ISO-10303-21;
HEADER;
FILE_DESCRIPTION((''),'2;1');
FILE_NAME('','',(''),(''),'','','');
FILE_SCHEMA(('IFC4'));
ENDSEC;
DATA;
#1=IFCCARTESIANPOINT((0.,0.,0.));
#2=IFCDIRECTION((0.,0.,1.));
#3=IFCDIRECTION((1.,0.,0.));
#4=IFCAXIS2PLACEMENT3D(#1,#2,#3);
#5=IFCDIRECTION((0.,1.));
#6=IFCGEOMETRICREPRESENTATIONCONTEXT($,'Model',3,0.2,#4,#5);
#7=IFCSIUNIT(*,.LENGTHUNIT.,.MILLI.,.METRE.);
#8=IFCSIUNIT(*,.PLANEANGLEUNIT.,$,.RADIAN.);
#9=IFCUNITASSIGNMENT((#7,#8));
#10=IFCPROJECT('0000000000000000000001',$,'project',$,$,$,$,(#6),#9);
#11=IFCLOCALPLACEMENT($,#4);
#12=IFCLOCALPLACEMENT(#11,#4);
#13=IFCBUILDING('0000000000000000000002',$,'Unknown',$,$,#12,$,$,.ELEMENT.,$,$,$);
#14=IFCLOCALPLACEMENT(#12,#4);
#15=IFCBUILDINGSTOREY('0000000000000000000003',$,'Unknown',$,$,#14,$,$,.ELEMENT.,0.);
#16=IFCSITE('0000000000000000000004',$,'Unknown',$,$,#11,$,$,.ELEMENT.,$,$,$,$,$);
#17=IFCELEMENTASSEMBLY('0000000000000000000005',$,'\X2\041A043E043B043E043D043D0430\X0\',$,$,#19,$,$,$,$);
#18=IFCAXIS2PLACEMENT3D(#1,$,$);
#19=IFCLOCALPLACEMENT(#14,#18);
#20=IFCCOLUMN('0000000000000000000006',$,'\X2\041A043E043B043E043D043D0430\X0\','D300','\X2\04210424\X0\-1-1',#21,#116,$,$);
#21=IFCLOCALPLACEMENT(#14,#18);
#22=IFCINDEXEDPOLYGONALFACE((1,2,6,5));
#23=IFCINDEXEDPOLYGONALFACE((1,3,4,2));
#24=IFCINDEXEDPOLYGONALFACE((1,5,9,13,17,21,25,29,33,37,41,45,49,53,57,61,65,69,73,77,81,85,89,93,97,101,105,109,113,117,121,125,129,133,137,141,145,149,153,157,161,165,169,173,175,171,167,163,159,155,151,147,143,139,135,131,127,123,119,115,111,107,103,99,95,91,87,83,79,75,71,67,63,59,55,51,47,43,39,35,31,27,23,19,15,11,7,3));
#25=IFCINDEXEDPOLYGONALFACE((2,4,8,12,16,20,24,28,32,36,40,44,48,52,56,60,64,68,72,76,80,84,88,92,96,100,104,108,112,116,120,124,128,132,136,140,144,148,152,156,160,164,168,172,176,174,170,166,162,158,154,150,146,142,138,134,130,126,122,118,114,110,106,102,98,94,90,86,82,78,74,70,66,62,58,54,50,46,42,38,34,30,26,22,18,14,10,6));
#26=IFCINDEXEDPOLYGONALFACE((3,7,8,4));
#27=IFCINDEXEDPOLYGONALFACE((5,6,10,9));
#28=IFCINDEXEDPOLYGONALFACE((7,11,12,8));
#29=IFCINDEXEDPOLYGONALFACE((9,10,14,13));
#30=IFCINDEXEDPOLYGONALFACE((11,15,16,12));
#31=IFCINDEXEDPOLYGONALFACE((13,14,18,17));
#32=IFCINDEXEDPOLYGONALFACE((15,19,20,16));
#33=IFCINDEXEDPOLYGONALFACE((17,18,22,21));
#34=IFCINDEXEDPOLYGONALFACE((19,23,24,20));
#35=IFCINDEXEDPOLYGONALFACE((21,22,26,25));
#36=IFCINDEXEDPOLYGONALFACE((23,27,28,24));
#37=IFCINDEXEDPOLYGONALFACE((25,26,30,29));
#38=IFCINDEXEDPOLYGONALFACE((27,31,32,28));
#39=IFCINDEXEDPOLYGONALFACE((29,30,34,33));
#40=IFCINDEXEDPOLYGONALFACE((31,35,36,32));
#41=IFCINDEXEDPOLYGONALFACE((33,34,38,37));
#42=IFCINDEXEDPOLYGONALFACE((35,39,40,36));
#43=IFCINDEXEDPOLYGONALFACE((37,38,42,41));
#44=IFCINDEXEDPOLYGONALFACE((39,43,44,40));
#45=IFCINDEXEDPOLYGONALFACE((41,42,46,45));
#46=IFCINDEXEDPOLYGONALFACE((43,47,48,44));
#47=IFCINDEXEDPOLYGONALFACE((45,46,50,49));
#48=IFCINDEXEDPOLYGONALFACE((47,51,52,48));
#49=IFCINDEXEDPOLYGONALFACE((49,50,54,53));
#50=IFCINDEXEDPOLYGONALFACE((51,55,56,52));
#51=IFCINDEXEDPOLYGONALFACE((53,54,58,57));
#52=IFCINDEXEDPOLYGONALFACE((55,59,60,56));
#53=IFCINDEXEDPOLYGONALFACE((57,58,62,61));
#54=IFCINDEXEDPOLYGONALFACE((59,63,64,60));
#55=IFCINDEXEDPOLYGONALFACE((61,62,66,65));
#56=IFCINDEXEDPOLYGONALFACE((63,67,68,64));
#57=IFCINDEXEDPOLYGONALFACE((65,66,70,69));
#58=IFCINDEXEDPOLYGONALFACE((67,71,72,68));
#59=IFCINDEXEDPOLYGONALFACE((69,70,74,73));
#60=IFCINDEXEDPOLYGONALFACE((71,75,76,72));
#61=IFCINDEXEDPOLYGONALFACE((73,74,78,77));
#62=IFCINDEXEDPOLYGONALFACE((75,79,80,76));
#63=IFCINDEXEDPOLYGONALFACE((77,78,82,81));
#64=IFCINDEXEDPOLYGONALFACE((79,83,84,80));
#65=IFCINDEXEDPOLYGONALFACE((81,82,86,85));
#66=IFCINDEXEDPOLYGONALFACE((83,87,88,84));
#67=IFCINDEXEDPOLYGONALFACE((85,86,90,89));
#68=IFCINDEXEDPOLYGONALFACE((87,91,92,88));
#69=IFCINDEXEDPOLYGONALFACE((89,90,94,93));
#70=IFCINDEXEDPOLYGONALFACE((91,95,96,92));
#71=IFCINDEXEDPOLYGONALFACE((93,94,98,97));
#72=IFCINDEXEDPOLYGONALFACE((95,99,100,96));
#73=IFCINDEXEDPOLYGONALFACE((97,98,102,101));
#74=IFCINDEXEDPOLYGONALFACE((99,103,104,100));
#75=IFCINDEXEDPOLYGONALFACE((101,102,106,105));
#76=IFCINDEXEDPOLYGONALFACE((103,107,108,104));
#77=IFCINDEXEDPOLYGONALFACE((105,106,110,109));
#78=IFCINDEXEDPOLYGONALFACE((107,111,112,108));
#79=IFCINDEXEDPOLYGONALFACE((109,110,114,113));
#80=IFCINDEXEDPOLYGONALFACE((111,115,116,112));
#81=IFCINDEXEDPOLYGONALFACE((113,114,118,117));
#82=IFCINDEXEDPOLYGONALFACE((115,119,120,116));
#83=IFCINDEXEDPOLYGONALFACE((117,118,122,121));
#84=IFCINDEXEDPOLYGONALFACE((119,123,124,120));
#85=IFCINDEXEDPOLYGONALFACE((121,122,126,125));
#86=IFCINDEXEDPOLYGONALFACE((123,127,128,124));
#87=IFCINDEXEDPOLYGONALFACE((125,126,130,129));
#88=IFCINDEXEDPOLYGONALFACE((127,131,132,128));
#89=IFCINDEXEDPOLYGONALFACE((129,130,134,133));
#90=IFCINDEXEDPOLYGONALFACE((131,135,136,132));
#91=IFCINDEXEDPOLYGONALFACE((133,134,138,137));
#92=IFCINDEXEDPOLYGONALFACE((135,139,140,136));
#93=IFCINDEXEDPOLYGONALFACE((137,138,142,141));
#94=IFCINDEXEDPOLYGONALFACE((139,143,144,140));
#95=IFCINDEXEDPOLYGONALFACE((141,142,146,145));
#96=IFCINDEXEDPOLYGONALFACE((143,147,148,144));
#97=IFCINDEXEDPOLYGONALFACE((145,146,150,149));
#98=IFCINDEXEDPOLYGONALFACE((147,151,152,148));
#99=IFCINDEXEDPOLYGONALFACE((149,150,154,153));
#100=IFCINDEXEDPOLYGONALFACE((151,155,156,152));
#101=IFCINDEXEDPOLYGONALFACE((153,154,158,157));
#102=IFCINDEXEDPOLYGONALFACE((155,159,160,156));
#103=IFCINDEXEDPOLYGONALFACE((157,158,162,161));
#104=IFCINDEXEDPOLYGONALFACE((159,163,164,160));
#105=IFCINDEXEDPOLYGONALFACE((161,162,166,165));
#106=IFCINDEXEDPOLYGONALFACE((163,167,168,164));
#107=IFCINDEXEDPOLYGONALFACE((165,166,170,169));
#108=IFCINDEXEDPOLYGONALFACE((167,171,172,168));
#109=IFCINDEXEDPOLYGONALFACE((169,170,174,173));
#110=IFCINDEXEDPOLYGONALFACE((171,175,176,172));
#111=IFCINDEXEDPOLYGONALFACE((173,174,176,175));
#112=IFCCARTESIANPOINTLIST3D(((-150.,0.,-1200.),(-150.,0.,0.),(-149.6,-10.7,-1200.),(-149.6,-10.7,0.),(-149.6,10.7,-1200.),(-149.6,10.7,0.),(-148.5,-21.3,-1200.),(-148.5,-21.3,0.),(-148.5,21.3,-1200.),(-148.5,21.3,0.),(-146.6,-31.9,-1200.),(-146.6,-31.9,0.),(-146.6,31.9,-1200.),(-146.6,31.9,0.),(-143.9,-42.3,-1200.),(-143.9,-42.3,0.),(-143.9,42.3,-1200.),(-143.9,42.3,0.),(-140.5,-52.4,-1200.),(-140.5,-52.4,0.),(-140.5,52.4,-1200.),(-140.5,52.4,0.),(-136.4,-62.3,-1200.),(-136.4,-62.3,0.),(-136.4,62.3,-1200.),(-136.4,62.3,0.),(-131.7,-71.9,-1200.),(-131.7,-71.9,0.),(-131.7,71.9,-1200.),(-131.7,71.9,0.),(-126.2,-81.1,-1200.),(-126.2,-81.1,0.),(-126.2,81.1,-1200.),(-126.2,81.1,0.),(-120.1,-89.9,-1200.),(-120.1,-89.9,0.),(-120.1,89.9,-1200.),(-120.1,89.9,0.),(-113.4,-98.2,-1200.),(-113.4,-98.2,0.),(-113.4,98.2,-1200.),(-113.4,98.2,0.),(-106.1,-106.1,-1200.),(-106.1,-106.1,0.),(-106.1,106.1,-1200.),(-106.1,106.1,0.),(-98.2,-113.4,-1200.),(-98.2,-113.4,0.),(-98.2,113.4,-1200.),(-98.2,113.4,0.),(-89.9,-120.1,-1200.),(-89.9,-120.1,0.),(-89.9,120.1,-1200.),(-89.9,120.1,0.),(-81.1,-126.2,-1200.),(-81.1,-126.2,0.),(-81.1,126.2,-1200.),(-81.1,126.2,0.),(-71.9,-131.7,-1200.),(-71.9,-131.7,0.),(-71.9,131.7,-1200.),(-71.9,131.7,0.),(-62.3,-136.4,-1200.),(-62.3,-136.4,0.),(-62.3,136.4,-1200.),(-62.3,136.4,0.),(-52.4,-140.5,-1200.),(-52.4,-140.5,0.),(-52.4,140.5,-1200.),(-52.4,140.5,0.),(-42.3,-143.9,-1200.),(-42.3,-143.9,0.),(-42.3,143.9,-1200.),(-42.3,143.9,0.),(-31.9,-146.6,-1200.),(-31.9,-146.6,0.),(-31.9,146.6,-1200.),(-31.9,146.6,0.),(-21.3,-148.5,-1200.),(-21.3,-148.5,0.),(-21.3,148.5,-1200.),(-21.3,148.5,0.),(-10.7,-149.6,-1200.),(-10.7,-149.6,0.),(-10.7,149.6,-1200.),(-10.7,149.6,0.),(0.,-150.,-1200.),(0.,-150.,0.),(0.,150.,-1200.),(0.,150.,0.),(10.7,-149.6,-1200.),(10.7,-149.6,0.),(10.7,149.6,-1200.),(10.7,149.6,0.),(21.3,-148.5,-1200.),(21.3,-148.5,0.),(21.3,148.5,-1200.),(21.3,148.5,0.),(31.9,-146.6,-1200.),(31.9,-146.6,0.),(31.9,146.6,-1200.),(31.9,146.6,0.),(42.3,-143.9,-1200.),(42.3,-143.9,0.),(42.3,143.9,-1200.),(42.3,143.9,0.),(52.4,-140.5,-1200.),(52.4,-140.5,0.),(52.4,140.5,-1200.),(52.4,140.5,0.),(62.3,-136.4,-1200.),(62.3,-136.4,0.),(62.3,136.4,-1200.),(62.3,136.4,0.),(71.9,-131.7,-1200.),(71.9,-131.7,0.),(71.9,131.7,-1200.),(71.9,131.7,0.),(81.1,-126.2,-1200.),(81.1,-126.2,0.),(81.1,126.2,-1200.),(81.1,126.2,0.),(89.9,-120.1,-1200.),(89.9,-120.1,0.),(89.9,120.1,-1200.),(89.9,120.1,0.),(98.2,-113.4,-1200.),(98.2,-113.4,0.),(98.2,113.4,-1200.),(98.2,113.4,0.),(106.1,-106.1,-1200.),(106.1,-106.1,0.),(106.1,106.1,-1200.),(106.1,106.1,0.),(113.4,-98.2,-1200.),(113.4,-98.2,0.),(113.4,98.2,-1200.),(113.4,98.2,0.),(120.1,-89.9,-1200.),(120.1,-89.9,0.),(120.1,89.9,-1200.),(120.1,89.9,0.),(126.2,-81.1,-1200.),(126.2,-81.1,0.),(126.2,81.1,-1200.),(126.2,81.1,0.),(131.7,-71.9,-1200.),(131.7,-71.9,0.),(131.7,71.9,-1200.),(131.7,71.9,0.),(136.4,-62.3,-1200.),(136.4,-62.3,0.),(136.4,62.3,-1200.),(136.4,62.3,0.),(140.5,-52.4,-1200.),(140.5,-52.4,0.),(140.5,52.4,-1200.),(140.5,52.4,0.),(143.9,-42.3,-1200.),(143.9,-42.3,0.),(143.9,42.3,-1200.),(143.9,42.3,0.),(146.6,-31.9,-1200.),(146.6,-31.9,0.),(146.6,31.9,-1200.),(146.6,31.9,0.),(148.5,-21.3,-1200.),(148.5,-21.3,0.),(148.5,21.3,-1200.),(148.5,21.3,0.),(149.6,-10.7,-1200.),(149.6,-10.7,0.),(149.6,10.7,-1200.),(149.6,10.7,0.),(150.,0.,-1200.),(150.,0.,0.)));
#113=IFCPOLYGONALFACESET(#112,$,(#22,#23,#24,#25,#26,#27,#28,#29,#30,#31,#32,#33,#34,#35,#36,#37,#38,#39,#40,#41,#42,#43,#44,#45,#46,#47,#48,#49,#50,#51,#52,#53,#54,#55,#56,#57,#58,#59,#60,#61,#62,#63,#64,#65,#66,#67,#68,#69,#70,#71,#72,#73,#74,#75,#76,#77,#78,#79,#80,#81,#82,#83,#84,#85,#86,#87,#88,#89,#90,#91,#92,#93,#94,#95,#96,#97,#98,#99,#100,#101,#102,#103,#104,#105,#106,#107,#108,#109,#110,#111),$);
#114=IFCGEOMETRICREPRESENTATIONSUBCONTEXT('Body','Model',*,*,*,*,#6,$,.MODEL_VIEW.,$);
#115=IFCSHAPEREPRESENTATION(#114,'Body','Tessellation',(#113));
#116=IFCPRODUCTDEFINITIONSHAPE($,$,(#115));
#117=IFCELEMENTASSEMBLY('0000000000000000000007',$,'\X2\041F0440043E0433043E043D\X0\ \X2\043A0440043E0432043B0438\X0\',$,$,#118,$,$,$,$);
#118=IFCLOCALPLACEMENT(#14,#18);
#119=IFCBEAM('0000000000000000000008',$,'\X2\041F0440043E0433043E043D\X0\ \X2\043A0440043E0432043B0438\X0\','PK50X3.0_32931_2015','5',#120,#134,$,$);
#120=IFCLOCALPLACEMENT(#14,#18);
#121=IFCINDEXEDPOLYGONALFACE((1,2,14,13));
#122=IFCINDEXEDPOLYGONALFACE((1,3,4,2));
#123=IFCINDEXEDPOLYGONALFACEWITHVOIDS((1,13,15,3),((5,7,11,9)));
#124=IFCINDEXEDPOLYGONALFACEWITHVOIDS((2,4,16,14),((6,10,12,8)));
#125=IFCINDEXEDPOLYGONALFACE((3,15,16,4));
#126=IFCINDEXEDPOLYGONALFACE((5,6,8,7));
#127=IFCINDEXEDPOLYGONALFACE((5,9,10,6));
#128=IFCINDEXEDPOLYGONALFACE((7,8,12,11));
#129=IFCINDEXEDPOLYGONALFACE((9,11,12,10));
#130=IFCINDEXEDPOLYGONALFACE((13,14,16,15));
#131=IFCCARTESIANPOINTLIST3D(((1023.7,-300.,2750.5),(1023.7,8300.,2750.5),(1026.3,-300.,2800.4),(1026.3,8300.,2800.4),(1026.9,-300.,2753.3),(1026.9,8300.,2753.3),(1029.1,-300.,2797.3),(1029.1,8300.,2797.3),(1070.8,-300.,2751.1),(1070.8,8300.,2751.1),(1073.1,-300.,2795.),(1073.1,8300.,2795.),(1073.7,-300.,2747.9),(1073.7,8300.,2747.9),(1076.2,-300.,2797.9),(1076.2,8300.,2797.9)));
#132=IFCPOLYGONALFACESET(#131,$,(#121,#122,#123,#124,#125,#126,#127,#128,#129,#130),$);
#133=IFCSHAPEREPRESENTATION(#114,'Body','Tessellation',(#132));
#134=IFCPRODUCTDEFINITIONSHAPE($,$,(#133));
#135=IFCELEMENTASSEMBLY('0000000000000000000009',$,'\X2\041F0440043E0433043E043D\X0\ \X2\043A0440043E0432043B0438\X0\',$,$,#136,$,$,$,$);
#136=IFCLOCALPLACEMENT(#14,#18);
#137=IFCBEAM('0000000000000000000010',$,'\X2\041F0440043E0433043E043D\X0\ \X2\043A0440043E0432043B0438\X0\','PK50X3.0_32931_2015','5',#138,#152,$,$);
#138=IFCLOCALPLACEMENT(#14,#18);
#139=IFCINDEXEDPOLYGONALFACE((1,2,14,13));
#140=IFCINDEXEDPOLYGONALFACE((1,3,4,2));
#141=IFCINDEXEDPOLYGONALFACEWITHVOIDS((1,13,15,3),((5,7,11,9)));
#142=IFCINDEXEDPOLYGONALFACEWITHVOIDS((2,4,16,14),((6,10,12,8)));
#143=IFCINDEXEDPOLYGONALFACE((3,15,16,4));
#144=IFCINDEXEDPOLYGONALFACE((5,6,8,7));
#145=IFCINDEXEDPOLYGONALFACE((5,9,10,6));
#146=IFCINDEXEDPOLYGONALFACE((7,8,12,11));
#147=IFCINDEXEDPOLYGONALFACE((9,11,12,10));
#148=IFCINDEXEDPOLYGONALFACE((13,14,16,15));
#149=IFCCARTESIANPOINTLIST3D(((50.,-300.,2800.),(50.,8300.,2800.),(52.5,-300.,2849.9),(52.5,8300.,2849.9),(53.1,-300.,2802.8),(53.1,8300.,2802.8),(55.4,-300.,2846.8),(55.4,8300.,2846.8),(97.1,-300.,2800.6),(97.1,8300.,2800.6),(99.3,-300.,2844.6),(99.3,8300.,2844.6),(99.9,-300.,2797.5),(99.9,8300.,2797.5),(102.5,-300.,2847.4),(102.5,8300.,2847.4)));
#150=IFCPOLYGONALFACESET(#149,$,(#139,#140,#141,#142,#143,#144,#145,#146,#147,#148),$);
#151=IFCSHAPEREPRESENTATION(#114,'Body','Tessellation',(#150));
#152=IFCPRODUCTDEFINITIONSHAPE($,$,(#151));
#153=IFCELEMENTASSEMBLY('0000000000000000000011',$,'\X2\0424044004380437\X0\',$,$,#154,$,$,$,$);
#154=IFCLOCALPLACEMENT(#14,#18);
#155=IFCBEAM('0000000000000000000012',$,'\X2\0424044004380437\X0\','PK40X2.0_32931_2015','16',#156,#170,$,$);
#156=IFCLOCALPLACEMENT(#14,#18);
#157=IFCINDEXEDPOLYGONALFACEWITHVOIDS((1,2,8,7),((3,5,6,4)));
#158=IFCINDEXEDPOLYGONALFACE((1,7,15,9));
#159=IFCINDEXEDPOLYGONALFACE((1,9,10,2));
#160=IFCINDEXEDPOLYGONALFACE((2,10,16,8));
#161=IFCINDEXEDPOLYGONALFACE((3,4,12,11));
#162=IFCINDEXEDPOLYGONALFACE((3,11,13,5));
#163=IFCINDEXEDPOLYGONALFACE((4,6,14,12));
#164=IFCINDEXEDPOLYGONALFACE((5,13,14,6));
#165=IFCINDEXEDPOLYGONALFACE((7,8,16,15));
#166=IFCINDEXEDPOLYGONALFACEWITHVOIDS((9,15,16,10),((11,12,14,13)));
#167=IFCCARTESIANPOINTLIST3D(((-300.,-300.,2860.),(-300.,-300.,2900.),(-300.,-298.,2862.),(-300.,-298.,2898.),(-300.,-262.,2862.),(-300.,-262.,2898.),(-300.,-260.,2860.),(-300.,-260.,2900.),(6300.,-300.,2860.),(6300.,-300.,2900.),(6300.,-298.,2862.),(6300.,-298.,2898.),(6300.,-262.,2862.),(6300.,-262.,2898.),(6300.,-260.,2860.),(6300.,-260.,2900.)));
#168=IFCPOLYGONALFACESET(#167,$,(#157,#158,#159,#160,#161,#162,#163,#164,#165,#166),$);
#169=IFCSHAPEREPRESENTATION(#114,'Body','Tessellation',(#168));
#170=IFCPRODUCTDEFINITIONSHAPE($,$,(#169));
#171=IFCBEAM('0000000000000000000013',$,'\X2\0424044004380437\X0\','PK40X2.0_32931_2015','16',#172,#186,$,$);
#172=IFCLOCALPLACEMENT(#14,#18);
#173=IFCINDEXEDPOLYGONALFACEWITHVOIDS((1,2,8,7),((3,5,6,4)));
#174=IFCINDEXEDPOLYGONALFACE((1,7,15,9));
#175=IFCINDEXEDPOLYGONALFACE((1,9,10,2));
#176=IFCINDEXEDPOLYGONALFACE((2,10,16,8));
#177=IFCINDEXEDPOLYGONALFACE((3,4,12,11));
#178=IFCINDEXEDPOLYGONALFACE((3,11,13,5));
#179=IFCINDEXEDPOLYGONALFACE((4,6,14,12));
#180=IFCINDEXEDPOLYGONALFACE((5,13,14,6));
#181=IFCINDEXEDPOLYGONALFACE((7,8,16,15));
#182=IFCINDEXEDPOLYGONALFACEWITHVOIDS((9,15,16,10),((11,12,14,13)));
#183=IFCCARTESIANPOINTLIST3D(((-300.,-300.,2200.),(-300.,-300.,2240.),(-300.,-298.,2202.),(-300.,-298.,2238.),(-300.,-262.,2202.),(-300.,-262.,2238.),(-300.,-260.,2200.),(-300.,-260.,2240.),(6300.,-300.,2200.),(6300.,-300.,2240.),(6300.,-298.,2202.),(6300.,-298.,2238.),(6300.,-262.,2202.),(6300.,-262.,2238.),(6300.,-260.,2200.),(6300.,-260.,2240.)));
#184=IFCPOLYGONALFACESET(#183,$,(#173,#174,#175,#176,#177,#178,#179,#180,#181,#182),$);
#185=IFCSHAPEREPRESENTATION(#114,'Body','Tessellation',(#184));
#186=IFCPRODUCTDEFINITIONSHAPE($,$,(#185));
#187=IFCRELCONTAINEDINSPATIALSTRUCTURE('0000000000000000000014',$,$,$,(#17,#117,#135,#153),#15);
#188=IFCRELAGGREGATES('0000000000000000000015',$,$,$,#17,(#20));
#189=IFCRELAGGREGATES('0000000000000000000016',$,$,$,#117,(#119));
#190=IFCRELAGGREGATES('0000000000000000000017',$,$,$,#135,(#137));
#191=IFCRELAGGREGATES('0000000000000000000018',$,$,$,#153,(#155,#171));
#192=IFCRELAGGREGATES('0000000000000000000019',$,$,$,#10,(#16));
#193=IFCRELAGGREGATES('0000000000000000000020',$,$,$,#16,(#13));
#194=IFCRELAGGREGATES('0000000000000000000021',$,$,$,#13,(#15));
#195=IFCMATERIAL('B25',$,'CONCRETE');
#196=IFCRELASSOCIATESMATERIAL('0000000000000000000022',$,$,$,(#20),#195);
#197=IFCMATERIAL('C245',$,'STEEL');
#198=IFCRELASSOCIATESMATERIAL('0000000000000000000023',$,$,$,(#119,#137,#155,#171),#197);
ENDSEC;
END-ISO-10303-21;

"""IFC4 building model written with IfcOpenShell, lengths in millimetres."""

from ifc_helpers import new_model, si_unit, direction, frame, origin_with_axes, place, context, subcontext, project, spatial, line, indexed_curve, outline, extrude, material, element, aggregate, save


model = new_model("IFC4")

# Units and contexts
model_context = context("Model", 3, precision=0.2, world=origin_with_axes(), true_north=direction((0.0, 1.0)))
body_context = subcontext(model_context, "Body", "Model", "MODEL_VIEW")
ifc_project = project(units=[si_unit("LENGTHUNIT", "METRE", prefix="MILLI"), si_unit("PLANEANGLEUNIT", "RADIAN")], contexts=[model_context])

# Site, building, storey
site_placement = place(None, origin_with_axes())
site = spatial("IfcSite", under=ifc_project, at=site_placement, Name="Unknown", CompositionType="ELEMENT")
building_placement = place(site_placement, origin_with_axes())
building = spatial("IfcBuilding", under=site, at=building_placement, Name="Unknown", CompositionType="ELEMENT")
storey_placement = place(building_placement, origin_with_axes())
storey = spatial("IfcBuildingStorey", under=building, at=storey_placement, Name="Unknown", CompositionType="ELEMENT", Elevation=0.0)

# Element assembly, column
assembly_1_placement = place(storey_placement, frame((0.0, 0.0, -1200.0), z_axis=(-1.0, 0.0, 0.0), x_axis=(0.0, 0.0, 1.0)))
assembly_1 = element("IfcElementAssembly", 1, at=assembly_1_placement, inside=storey, Name="Колонна")
ifc_material_1 = material(Name="B25", Category="CONCRETE")
column_placement = place(assembly_1_placement, origin_with_axes())
column = element("IfcColumn", 2, at=column_placement, material=ifc_material_1, Name="Колонна", Description="D300", ObjectType="СФ-1-1", context=body_context, shape_type="SolidModel", body=[
    extrude(outline(indexed_curve([(150.0, 0.0), (149.6, 10.7), (148.5, 21.3), (146.6, 31.9), (143.9, 42.3), (140.5, 52.4), (136.4, 62.3), (131.7, 71.9), (126.2, 81.1), (120.1, 89.9), (113.4, 98.2), (106.1, 106.1), (98.2, 113.4), (89.9, 120.1), (81.1, 126.2), (71.9, 131.7), (62.3, 136.4), (52.4, 140.5), (42.3, 143.9), (31.9, 146.6), (21.3, 148.5), (10.7, 149.6), (0.0, 150.0), (-10.7, 149.6), (-21.3, 148.5), (-31.9, 146.6), (-42.3, 143.9), (-52.4, 140.5), (-62.3, 136.4), (-71.9, 131.7), (-81.1, 126.2), (-89.9, 120.1), (-98.2, 113.4), (-106.1, 106.1), (-113.4, 98.2), (-120.1, 89.9), (-126.2, 81.1), (-131.7, 71.9), (-136.4, 62.3), (-140.5, 52.4), (-143.9, 42.3), (-146.6, 31.9), (-148.5, 21.3), (-149.6, 10.7), (-150.0, 0.0), (-149.6, -10.7), (-148.5, -21.3), (-146.6, -31.9), (-143.9, -42.3), (-140.5, -52.4), (-136.4, -62.3), (-131.7, -71.9), (-126.2, -81.1), (-120.1, -89.9), (-113.4, -98.2), (-106.1, -106.1), (-98.2, -113.4), (-89.9, -120.1), (-81.1, -126.2), (-71.9, -131.7), (-62.3, -136.4), (-52.4, -140.5), (-42.3, -143.9), (-31.9, -146.6), (-21.3, -148.5), (-10.7, -149.6), (0.0, -150.0), (10.7, -149.6), (21.3, -148.5), (31.9, -146.6), (42.3, -143.9), (52.4, -140.5), (62.3, -136.4), (71.9, -131.7), (81.1, -126.2), (89.9, -120.1), (98.2, -113.4), (106.1, -106.1), (113.4, -98.2), (120.1, -89.9), (126.2, -81.1), (131.7, -71.9), (136.4, -62.3), (140.5, -52.4), (143.9, -42.3), (146.6, -31.9), (148.5, -21.3), (149.6, -10.7)], segments=[line(1, 2, 3, 4, 5, 6, 7, 8, 9, 10, 11, 12, 13, 14, 15, 16, 17, 18, 19, 20, 21, 22, 23, 24, 25, 26, 27, 28, 29, 30, 31, 32, 33, 34, 35, 36, 37, 38, 39, 40, 41, 42, 43, 44, 45, 46, 47, 48, 49, 50, 51, 52, 53, 54, 55, 56, 57, 58, 59, 60, 61, 62, 63, 64, 65, 66, 67, 68, 69, 70, 71, 72, 73, 74, 75, 76, 77, 78, 79, 80, 81, 82, 83, 84, 85, 86, 87, 88, 1)])), frame((0.0, 0.0, 0.0), z_axis=(-1.0, 0.0, 0.0), x_axis=(0.0, 0.0, 1.0)), (0.0, 0.0, -1.0), 1200.0),
])
aggregate(assembly_1, [column])

# Element assemblies, beams
assembly_2_placement = place(storey_placement, frame((1050.0, -300.0, 2774.2), z_axis=(0.99871, 0.0, -0.050782), x_axis=(0.0, 1.0, 0.0)))
assembly_2 = element("IfcElementAssembly", 3, at=assembly_2_placement, inside=storey, Name="Прогон кровли")
ifc_material_2 = material(Name="C245", Category="STEEL")
beam_1_placement = place(assembly_2_placement, origin_with_axes())
beam_1 = element("IfcBeam", 4, at=beam_1_placement, material=ifc_material_2, Name="Прогон кровли", Description="PK50X3.0_32931_2015", ObjectType="5", context=body_context, shape_type="SolidModel", body=[
    extrude(outline(indexed_curve([(-25.0, -25.0), (25.0, -25.0), (25.0, 25.0), (-25.0, 25.0)], segments=[line(1, 2, 3, 4, 1)]), holes=[indexed_curve([(-22.0, -22.0), (-22.0, 22.0), (22.0, 22.0), (22.0, -22.0)], segments=[line(1, 2, 3, 4, 1)])]), frame((0.0, 0.0, 0.0), z_axis=(-1.0, 0.0, 0.0), x_axis=(0.0, 0.0, 1.0)), (0.0, 0.0, -1.0), 8600.0),
])
aggregate(assembly_2, [beam_1])
assembly_3_placement = place(storey_placement, frame((76.2, -300.0, 2823.7), z_axis=(0.99871, 0.0, -0.050782), x_axis=(0.0, 1.0, 0.0)))
assembly_3 = element("IfcElementAssembly", 5, at=assembly_3_placement, inside=storey, Name="Прогон кровли")
beam_2_placement = place(assembly_3_placement, origin_with_axes())
beam_2 = element("IfcBeam", 6, at=beam_2_placement, material=ifc_material_2, Name="Прогон кровли", Description="PK50X3.0_32931_2015", ObjectType="5", context=body_context, shape_type="SolidModel", body=[
    extrude(outline(indexed_curve([(-25.0, -25.0), (25.0, -25.0), (25.0, 25.0), (-25.0, 25.0)], segments=[line(1, 2, 3, 4, 1)]), holes=[indexed_curve([(-22.0, -22.0), (-22.0, 22.0), (22.0, 22.0), (22.0, -22.0)], segments=[line(1, 2, 3, 4, 1)])]), frame((0.0, 0.0, 0.0), z_axis=(-1.0, 0.0, 0.0), x_axis=(0.0, 0.0, 1.0)), (0.0, 0.0, -1.0), 8600.0),
])
aggregate(assembly_3, [beam_2])

# Element assembly, beams
assembly_4_placement = place(storey_placement, frame((-300.0, -280.0, 2880.0), z_axis=(0.0, -1.0, 0.0), x_axis=(1.0, 0.0, 0.0)))
assembly_4 = element("IfcElementAssembly", 7, at=assembly_4_placement, inside=storey, Name="Фриз")
beam_3_placement = place(assembly_4_placement, origin_with_axes())
beam_3 = element("IfcBeam", 8, at=beam_3_placement, material=ifc_material_2, Name="Фриз", Description="PK40X2.0_32931_2015", ObjectType="16", context=body_context, shape_type="SolidModel", body=[
    extrude(outline(indexed_curve([(-20.0, -20.0), (20.0, -20.0), (20.0, 20.0), (-20.0, 20.0)], segments=[line(1, 2, 3, 4, 1)]), holes=[indexed_curve([(-18.0, -18.0), (-18.0, 18.0), (18.0, 18.0), (18.0, -18.0)], segments=[line(1, 2, 3, 4, 1)])]), frame((0.0, 0.0, 0.0), z_axis=(-1.0, 0.0, 0.0), x_axis=(0.0, 0.0, 1.0)), (0.0, 0.0, -1.0), 6600.0),
])
beam_4_placement = place(assembly_4_placement, frame((0.0, -660.0, 0.0), z_axis=(0.0, 0.0, 1.0), x_axis=(1.0, 0.0, 0.0)))
beam_4 = element("IfcBeam", 9, at=beam_4_placement, material=ifc_material_2, Name="Фриз", Description="PK40X2.0_32931_2015", ObjectType="16", context=body_context, shape_type="SolidModel", body=[
    extrude(outline(indexed_curve([(-20.0, -20.0), (20.0, -20.0), (20.0, 20.0), (-20.0, 20.0)], segments=[line(1, 2, 3, 4, 1)]), holes=[indexed_curve([(-18.0, -18.0), (-18.0, 18.0), (18.0, 18.0), (18.0, -18.0)], segments=[line(1, 2, 3, 4, 1)])]), frame((0.0, 0.0, 0.0), z_axis=(-1.0, 0.0, 0.0), x_axis=(0.0, 0.0, 1.0)), (0.0, 0.0, -1.0), 6600.0),
])
aggregate(assembly_4, [beam_3, beam_4])

save(model, "model.ifc")
